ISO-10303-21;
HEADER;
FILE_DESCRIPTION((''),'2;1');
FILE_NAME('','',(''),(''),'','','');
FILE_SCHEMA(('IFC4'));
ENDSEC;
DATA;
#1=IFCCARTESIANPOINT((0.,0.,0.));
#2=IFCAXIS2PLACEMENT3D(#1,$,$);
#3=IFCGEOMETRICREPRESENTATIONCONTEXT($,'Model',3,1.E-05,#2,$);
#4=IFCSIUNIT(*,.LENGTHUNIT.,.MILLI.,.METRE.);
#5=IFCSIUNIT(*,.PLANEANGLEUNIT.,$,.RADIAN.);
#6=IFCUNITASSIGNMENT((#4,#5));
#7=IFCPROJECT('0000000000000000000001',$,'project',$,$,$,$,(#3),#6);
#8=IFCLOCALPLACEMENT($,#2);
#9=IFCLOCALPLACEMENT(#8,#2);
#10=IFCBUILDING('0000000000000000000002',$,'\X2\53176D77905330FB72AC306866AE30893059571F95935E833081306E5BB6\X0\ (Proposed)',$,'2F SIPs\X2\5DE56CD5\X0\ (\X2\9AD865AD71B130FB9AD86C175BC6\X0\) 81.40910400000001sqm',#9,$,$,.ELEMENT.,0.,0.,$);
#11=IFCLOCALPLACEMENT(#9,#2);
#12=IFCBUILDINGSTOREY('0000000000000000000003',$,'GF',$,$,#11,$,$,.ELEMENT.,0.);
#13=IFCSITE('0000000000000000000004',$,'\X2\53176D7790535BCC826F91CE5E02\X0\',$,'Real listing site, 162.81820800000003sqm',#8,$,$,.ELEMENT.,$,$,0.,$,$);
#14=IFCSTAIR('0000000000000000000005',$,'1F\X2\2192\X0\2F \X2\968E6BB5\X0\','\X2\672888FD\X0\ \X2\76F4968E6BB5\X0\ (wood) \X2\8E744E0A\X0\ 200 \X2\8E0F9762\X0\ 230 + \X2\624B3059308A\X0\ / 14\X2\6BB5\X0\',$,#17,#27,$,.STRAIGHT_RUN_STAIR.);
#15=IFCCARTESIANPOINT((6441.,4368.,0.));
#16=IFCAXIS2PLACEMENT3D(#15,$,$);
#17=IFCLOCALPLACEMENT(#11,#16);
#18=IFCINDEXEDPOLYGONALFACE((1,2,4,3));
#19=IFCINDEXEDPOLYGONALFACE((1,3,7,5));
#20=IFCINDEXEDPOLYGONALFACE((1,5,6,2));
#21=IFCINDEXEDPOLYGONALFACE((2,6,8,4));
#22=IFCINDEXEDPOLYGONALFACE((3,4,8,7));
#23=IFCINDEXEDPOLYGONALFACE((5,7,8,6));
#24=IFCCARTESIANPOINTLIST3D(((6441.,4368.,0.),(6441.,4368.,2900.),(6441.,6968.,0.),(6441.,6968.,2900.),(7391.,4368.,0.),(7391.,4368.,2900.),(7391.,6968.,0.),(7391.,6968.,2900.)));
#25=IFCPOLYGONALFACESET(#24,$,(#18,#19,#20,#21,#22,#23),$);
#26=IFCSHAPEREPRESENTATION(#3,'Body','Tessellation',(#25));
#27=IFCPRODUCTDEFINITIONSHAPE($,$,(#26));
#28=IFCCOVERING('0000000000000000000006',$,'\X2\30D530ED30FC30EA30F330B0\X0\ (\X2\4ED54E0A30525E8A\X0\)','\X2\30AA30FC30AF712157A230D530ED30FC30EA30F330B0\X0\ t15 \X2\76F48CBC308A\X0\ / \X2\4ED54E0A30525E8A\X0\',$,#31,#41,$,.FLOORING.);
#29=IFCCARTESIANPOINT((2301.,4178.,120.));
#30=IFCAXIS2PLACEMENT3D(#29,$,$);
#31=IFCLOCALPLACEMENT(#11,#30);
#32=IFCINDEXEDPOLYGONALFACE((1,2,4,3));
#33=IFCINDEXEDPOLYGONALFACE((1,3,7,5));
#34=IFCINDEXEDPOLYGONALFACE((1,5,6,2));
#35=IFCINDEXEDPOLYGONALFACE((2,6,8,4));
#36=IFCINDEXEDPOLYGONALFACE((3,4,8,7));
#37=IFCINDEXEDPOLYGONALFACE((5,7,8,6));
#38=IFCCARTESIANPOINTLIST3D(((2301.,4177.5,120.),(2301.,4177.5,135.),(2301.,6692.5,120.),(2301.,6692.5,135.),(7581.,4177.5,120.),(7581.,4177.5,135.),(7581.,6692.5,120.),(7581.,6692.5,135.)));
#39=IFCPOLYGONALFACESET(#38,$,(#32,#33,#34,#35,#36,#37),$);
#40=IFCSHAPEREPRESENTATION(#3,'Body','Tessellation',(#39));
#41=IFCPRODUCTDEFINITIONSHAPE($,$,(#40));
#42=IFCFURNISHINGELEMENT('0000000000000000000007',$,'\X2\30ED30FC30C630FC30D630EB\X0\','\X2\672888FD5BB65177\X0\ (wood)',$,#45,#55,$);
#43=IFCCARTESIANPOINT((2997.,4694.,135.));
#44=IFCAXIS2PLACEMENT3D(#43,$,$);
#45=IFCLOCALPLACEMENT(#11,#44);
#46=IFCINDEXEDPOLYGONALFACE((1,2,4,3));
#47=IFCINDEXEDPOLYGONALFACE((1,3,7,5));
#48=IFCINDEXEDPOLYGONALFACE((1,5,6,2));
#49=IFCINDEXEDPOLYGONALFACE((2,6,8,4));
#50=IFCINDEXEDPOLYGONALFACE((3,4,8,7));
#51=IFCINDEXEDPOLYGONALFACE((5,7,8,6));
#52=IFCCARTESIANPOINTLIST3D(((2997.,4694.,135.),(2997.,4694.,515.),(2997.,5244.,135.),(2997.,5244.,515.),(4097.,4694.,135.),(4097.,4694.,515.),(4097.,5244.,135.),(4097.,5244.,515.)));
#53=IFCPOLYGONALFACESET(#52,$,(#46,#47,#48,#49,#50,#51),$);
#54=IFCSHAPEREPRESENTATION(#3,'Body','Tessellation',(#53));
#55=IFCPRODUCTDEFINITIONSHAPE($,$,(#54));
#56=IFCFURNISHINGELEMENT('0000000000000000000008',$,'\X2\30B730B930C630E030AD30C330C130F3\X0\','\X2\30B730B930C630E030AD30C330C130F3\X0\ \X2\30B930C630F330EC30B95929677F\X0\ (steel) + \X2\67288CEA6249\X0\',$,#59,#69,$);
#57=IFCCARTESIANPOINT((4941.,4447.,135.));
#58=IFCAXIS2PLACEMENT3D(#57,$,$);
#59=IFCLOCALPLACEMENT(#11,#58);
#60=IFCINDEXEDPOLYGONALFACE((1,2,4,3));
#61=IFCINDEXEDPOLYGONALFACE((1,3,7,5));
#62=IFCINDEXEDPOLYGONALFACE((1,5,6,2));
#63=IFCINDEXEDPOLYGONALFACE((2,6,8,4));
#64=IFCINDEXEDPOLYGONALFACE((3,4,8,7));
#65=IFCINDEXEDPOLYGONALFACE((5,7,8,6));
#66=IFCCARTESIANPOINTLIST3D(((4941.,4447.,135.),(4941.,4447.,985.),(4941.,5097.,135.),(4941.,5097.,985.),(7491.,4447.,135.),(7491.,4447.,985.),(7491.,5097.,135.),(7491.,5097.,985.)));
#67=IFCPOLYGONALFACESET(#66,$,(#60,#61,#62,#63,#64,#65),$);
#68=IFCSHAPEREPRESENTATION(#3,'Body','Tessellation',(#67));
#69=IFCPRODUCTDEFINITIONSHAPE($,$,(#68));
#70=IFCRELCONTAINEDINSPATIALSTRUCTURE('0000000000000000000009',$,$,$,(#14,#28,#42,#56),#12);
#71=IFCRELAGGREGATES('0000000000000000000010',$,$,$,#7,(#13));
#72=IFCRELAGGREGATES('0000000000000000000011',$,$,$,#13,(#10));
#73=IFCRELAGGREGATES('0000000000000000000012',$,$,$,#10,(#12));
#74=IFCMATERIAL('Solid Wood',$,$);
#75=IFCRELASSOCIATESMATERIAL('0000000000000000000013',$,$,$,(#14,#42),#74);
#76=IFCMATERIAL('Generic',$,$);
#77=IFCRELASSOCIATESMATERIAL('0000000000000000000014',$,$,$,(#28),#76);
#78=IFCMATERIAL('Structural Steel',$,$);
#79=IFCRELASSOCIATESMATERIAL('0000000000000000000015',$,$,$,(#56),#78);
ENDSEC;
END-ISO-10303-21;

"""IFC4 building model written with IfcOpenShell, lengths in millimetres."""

from ifc_helpers import new_model, si_unit, frame, frame_2d, origin, place, context, project, spatial, rectangle, extrude, material, element, save


model = new_model("IFC4")

# Units and contexts
model_context = context("Model", 3, precision=1e-05, world=origin())
ifc_project = project(units=[si_unit("LENGTHUNIT", "METRE", prefix="MILLI"), si_unit("PLANEANGLEUNIT", "RADIAN")], contexts=[model_context])

# Site, building, storey
site_placement = place(None, origin())
site = spatial("IfcSite", under=ifc_project, at=site_placement, Name="北海道富良野市", ObjectType="Real listing site, 162.81820800000003sqm", CompositionType="ELEMENT", RefElevation=0.0)
building_placement = place(site_placement, origin())
building = spatial("IfcBuilding", under=site, at=building_placement, Name="北海道・犬と暮らす土間広めの家 (Proposed)", ObjectType="2F SIPs工法 (高断熱・高気密) 81.40910400000001sqm", CompositionType="ELEMENT", ElevationOfRefHeight=0.0, ElevationOfTerrain=0.0)
storey_placement = place(building_placement, origin())
storey = spatial("IfcBuildingStorey", under=building, at=storey_placement, Name="GF", CompositionType="ELEMENT", Elevation=0.0)

# Shared definitions
ifc_material_1 = material(Name="Solid Wood")

# Stair
stair_placement = place(storey_placement, frame((6441.0, 4368.0, 0.0)))
element("IfcStair", 1, at=stair_placement, inside=storey, material=ifc_material_1, Name="1F→2F 階段", Description="木製 直階段 (wood) 蹴上 200 踏面 230 + 手すり / 14段", PredefinedType="STRAIGHT_RUN_STAIR", context=model_context, shape_type="SweptSolid", body=[
    extrude(rectangle(XDim=950.0, YDim=2600.0, at=frame_2d((475.0, 1300.0))), frame((6441.0, 4368.0, 0.0)), (0.0, 0.0, 1.0), 2900.0),
])

# Covering
ifc_material_2 = material(Name="Generic")
covering_placement = place(storey_placement, frame((2301.0, 4178.0, 120.0)))
element("IfcCovering", 2, at=covering_placement, inside=storey, material=ifc_material_2, Name="フローリング (仕上げ床)", Description="オーク無垢フローリング t15 直貼り / 仕上げ床", PredefinedType="FLOORING", context=model_context, shape_type="SweptSolid", body=[
    extrude(rectangle(XDim=5280.0, YDim=2515.0, at=frame_2d((2640.0, 1257.0))), frame((2301.0, 4178.0, 120.0)), (0.0, 0.0, 1.0), 15.0),
])

# Furnishing elements
furnishing_1_placement = place(storey_placement, frame((2997.0, 4694.0, 135.0)))
element("IfcFurnishingElement", 3, at=furnishing_1_placement, inside=storey, material=ifc_material_1, Name="ローテーブル", Description="木製家具 (wood)", context=model_context, shape_type="SweptSolid", body=[
    extrude(rectangle(XDim=1100.0, YDim=550.0, at=frame_2d((550.0, 275.0))), frame((2997.0, 4694.0, 135.0)), (0.0, 0.0, 1.0), 380.0),
])
ifc_material_3 = material(Name="Structural Steel")
furnishing_2_placement = place(storey_placement, frame((4941.0, 4447.0, 135.0)))
element("IfcFurnishingElement", 4, at=furnishing_2_placement, inside=storey, material=ifc_material_3, Name="システムキッチン", Description="システムキッチン ステンレス天板 (steel) + 木質扉", context=model_context, shape_type="SweptSolid", body=[
    extrude(rectangle(XDim=2550.0, YDim=650.0, at=frame_2d((1275.0, 325.0))), frame((4941.0, 4447.0, 135.0)), (0.0, 0.0, 1.0), 850.0),
])

save(model, "model.ifc")
